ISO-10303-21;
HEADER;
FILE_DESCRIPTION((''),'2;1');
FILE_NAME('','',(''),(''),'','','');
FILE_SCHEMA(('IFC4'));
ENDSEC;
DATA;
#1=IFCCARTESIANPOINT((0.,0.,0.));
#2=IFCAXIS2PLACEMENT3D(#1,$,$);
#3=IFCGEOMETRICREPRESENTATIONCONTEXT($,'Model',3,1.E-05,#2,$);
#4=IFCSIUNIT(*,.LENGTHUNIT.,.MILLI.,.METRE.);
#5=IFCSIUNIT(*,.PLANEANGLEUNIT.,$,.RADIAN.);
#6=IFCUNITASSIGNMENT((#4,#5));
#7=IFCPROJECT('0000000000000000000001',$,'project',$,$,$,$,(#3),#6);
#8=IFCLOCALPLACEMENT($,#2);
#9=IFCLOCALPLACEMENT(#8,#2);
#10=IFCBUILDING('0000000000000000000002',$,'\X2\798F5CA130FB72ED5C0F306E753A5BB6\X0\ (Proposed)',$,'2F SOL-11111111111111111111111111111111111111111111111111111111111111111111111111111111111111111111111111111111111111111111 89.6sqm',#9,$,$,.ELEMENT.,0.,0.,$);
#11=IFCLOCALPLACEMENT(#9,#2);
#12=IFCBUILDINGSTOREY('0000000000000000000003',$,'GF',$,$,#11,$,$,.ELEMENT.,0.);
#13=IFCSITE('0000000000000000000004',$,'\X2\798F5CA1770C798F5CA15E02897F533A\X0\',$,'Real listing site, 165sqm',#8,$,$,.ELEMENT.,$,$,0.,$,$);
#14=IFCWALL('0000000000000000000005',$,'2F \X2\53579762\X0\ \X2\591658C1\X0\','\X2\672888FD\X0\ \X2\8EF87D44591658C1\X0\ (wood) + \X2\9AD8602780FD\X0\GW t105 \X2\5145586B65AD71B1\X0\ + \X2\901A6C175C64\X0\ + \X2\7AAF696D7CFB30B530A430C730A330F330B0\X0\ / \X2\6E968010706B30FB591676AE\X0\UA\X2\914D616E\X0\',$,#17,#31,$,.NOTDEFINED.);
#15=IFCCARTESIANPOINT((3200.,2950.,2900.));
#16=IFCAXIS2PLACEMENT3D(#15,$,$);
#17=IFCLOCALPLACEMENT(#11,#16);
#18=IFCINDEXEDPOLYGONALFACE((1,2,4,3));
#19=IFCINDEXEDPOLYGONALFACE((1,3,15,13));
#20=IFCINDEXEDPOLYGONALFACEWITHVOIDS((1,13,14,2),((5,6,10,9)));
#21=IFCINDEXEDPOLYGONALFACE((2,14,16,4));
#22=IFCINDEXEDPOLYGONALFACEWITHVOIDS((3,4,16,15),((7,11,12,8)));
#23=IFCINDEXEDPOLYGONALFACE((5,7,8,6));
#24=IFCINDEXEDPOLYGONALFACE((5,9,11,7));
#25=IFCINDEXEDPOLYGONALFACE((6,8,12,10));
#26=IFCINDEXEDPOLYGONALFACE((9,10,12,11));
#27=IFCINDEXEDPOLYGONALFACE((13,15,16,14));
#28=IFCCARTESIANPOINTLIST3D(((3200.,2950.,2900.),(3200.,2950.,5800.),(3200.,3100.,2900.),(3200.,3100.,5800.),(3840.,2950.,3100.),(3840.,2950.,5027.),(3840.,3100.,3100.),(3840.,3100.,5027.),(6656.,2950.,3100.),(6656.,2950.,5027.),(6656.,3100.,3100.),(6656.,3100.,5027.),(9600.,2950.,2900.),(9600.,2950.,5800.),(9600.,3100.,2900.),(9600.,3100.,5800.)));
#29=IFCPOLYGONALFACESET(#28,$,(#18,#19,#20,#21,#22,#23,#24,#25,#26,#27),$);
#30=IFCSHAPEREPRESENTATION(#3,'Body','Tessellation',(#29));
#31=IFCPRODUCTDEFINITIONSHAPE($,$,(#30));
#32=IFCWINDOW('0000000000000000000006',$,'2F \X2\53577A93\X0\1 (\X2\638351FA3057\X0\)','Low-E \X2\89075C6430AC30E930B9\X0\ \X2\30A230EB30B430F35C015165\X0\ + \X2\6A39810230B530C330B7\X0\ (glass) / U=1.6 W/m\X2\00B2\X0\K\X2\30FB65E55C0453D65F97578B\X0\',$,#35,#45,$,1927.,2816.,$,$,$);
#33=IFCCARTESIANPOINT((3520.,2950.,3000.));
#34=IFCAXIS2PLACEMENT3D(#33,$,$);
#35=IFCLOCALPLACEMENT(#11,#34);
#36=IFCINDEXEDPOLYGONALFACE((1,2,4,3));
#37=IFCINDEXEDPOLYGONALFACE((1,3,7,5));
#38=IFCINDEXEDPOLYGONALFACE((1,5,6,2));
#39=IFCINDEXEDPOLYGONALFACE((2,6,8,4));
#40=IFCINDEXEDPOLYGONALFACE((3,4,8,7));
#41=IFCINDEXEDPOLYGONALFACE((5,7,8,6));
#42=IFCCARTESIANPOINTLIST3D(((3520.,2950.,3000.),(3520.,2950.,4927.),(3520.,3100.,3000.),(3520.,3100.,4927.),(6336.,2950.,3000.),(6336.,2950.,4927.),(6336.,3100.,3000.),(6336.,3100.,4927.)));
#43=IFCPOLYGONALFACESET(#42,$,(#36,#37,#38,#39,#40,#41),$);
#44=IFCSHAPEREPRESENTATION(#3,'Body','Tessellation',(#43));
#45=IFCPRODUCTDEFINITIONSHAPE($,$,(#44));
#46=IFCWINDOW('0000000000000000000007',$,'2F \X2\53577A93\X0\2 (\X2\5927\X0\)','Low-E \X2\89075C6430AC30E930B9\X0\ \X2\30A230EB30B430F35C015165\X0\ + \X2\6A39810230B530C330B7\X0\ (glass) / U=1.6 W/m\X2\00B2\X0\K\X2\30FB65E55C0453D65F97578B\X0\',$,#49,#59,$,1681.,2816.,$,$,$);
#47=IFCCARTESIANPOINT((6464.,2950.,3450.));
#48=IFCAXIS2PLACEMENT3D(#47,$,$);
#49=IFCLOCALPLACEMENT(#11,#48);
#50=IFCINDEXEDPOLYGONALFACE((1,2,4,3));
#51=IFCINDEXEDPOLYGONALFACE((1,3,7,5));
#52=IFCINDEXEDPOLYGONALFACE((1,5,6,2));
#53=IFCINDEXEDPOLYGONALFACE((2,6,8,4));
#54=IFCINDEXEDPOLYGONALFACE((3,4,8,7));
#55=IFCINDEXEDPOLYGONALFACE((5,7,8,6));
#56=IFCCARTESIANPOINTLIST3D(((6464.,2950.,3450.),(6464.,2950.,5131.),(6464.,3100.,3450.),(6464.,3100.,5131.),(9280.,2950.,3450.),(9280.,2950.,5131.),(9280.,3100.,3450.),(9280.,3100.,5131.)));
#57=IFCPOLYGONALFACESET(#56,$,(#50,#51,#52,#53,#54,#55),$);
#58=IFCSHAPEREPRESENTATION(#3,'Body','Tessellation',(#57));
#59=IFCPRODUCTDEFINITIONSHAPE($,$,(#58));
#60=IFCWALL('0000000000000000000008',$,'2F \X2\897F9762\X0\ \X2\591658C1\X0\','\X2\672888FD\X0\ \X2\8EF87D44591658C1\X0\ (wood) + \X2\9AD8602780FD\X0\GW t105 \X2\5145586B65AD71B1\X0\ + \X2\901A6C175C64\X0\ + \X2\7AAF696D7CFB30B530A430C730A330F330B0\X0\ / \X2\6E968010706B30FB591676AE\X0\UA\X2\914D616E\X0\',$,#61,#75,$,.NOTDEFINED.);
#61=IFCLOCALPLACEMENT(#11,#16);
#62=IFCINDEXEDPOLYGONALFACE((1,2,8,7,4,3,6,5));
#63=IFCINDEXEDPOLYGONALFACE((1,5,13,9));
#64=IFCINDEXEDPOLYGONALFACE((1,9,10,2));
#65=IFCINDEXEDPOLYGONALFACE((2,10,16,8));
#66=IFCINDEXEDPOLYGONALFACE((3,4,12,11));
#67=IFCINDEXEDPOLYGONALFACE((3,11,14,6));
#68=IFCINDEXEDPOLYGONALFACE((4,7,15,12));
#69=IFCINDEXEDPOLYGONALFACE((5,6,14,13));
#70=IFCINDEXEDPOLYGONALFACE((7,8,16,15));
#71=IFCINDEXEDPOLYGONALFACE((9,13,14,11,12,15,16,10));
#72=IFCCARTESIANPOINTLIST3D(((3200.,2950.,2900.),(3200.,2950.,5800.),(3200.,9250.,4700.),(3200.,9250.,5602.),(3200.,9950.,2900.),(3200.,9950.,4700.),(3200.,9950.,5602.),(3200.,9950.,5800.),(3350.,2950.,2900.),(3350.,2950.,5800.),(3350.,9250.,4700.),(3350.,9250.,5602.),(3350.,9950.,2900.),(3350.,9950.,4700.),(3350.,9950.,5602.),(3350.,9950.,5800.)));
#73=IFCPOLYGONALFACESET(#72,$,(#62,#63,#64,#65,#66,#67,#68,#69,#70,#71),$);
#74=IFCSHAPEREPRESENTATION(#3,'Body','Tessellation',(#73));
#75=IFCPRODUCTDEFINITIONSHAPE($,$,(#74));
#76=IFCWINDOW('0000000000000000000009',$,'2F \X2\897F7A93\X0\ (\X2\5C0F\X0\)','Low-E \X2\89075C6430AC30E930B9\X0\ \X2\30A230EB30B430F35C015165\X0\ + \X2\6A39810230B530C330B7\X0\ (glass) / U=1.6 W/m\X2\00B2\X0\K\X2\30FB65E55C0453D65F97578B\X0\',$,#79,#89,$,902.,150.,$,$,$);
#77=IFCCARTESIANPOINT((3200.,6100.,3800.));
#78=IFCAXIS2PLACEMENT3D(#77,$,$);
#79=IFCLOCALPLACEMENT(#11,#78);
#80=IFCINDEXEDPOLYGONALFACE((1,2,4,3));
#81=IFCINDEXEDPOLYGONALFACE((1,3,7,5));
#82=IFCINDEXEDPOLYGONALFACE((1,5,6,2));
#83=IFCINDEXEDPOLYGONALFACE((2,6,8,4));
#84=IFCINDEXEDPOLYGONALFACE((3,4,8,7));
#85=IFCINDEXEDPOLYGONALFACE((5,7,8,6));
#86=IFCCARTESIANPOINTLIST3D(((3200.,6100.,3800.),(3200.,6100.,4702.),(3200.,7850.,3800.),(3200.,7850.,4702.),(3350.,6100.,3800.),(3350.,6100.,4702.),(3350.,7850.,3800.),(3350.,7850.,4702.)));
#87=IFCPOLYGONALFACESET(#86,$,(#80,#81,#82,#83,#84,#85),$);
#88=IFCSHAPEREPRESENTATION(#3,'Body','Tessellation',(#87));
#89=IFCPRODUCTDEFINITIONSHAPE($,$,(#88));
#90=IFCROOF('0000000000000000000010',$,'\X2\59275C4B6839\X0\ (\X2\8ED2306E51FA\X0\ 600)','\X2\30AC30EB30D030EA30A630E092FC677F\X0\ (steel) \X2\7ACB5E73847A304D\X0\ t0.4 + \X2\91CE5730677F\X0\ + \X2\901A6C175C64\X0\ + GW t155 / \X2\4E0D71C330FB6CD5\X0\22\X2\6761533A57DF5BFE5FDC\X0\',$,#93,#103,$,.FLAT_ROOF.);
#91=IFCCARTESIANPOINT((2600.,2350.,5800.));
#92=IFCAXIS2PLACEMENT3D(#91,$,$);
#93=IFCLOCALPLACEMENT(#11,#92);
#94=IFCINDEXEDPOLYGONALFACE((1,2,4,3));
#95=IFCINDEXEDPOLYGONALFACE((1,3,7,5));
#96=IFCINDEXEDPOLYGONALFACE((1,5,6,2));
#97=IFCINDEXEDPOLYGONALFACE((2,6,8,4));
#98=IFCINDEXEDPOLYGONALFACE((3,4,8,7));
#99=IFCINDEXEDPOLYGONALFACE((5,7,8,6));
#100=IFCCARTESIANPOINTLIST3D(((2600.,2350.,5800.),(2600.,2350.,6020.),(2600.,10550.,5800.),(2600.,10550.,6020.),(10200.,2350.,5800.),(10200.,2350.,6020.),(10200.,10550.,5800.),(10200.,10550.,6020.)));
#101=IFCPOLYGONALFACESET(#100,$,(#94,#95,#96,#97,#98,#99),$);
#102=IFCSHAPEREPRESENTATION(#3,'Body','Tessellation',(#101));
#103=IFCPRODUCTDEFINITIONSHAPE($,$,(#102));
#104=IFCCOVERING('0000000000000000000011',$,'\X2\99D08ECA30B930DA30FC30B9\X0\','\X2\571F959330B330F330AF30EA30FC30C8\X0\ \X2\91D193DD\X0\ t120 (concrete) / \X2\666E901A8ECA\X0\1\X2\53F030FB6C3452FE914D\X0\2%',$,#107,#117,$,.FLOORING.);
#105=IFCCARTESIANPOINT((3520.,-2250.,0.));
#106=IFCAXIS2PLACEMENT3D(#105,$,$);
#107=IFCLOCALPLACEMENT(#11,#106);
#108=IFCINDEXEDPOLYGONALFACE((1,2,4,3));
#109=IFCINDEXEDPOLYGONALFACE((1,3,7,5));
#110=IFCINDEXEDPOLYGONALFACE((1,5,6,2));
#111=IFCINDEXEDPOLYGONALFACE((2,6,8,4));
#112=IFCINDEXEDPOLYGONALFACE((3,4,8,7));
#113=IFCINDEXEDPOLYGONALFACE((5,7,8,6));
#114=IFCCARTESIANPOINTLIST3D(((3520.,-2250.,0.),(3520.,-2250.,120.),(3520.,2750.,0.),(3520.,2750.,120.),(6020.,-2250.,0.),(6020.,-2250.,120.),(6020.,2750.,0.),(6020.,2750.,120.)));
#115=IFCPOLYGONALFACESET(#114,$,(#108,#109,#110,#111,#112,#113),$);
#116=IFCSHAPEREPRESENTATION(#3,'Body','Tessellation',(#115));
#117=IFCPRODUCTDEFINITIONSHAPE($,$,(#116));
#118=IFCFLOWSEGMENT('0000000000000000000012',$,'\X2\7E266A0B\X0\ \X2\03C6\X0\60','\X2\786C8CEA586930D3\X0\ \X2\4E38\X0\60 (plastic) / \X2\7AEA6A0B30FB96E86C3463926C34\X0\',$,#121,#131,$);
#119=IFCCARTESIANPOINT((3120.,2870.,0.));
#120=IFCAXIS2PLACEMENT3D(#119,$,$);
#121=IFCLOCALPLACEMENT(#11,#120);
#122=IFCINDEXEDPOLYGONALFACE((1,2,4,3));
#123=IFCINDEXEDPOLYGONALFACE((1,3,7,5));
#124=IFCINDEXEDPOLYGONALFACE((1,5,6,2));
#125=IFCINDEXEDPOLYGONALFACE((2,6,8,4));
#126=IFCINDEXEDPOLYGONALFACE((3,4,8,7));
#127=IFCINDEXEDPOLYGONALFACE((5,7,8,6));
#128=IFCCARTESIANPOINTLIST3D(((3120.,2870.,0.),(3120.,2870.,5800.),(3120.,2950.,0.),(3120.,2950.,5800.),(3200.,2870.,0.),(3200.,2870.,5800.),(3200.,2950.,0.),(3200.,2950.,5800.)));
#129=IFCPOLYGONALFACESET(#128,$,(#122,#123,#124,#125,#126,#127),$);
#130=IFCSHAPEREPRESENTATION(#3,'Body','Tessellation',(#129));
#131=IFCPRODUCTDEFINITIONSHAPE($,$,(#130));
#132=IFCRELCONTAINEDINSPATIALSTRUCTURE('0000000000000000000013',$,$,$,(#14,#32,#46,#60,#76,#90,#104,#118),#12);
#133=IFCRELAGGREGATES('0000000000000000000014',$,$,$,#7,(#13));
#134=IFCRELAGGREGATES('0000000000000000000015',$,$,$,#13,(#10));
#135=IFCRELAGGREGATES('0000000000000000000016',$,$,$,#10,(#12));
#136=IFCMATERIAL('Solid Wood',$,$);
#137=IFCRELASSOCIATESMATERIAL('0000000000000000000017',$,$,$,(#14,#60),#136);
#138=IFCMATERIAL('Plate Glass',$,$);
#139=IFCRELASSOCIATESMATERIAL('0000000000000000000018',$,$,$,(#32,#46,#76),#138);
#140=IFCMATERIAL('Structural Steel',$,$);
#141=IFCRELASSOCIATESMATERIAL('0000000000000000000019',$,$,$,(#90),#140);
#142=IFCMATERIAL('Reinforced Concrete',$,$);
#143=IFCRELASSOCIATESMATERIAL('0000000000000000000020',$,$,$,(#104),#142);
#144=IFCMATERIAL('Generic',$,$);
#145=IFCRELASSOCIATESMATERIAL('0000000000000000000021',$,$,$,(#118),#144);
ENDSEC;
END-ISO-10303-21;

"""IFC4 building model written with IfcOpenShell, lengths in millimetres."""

from ifc_helpers import new_model, si_unit, frame, frame_2d, origin, place, context, project, spatial, rectangle, extrude, material, element, fill, save


model = new_model("IFC4")

# Units and contexts
model_context = context("Model", 3, precision=1e-05, world=origin())
ifc_project = project(units=[si_unit("LENGTHUNIT", "METRE", prefix="MILLI"), si_unit("PLANEANGLEUNIT", "RADIAN")], contexts=[model_context])

# Site, building, storey
site_placement = place(None, origin())
site = spatial("IfcSite", under=ifc_project, at=site_placement, Name="福岡県福岡市西区", ObjectType="Real listing site, 165sqm", CompositionType="ELEMENT", RefElevation=0.0)
building_placement = place(site_placement, origin())
building = spatial("IfcBuilding", under=site, at=building_placement, Name="福岡・狭小の町家 (Proposed)", ObjectType="2F SOL-11111111111111111111111111111111111111111111111111111111111111111111111111111111111111111111111111111111111111111111 89.6sqm", CompositionType="ELEMENT", ElevationOfRefHeight=0.0, ElevationOfTerrain=0.0)
storey_placement = place(building_placement, origin())
storey = spatial("IfcBuildingStorey", under=building, at=storey_placement, Name="GF", CompositionType="ELEMENT", Elevation=0.0)

# Shared definitions
ifc_material_1 = material(Name="Solid Wood")

# Shared definitions
ifc_material_2 = material(Name="Reinforced Concrete")

# Shared definitions
ifc_material_3 = material(Name="Plate Glass")

# Wall, openings, windows
wall_1_placement = place(storey_placement, frame((3200.0, 2950.0, 2900.0)))
wall_1 = element("IfcWall", 1, at=wall_1_placement, inside=storey, material=ifc_material_1, Name="2F 南面 外壁", Description="木製 軸組外壁 (wood) + 高性能GW t105 充填断熱 + 通気層 + 窯業系サイディング / 準耐火・外皮UA配慮", PredefinedType="NOTDEFINED", context=model_context, shape_type="SweptSolid", body=[
    extrude(rectangle(XDim=6400.0, YDim=150.0, at=frame_2d((3200.0, 75.0))), frame((3200.0, 2950.0, 2900.0)), (0.0, 0.0, 1.0), 2900.0),
])
opening_1_placement = place(storey_placement, frame((3520.0, 2950.0, 3000.0)))
opening_1 = element("IfcOpeningElement", 2, at=opening_1_placement, cuts=wall_1, PredefinedType="NOTDEFINED", context=model_context, shape_type="SweptSolid", body=[
    extrude(rectangle(XDim=2816.0, YDim=150.0, at=frame_2d((1408.0, 75.0))), frame((3520.0, 2950.0, 3000.0)), (0.0, 0.0, 1.0), 1927.0),
])
opening_2_placement = place(storey_placement, frame((6464.0, 2950.0, 3450.0)))
opening_2 = element("IfcOpeningElement", 3, at=opening_2_placement, cuts=wall_1, PredefinedType="NOTDEFINED", context=model_context, shape_type="SweptSolid", body=[
    extrude(rectangle(XDim=2816.0, YDim=150.0, at=frame_2d((1408.0, 75.0))), frame((6464.0, 2950.0, 3450.0)), (0.0, 0.0, 1.0), 1681.0),
])
window_1_placement = place(storey_placement, frame((3520.0, 2950.0, 3000.0)))
window_1 = element("IfcWindow", 4, at=window_1_placement, inside=storey, material=ifc_material_3, Name="2F 南窓1 (掃出し)", Description="Low-E 複層ガラス アルゴン封入 + 樹脂サッシ (glass) / U=1.6 W/m²K・日射取得型", OverallHeight=1927.0, OverallWidth=2816.0, context=model_context, shape_type="SweptSolid", body=[
    extrude(rectangle(XDim=2816.0, YDim=150.0, at=frame_2d((1408.0, 75.0))), frame((3520.0, 2950.0, 3000.0)), (0.0, 0.0, 1.0), 1927.0),
])
fill(opening_1, window_1)
window_2_placement = place(storey_placement, frame((6464.0, 2950.0, 3450.0)))
window_2 = element("IfcWindow", 5, at=window_2_placement, inside=storey, material=ifc_material_3, Name="2F 南窓2 (大)", Description="Low-E 複層ガラス アルゴン封入 + 樹脂サッシ (glass) / U=1.6 W/m²K・日射取得型", OverallHeight=1681.0, OverallWidth=2816.0, context=model_context, shape_type="SweptSolid", body=[
    extrude(rectangle(XDim=2816.0, YDim=150.0, at=frame_2d((1408.0, 75.0))), frame((6464.0, 2950.0, 3450.0)), (0.0, 0.0, 1.0), 1681.0),
])
fill(opening_2, window_2)

# Wall, opening, window
wall_2_placement = place(storey_placement, frame((3200.0, 2950.0, 2900.0)))
wall_2 = element("IfcWall", 6, at=wall_2_placement, inside=storey, material=ifc_material_1, Name="2F 西面 外壁", Description="木製 軸組外壁 (wood) + 高性能GW t105 充填断熱 + 通気層 + 窯業系サイディング / 準耐火・外皮UA配慮", PredefinedType="NOTDEFINED", context=model_context, shape_type="SweptSolid", body=[
    extrude(rectangle(XDim=150.0, YDim=7000.0, at=frame_2d((75.0, 3500.0))), frame((3200.0, 2950.0, 2900.0)), (0.0, 0.0, 1.0), 2900.0),
])
opening_3_placement = place(storey_placement, frame((3200.0, 6100.0, 3800.0)))
opening_3 = element("IfcOpeningElement", 7, at=opening_3_placement, cuts=wall_2, PredefinedType="NOTDEFINED", context=model_context, shape_type="SweptSolid", body=[
    extrude(rectangle(XDim=150.0, YDim=1750.0, at=frame_2d((75.0, 875.0))), frame((3200.0, 6100.0, 3800.0)), (0.0, 0.0, 1.0), 902.0),
])
window_3_placement = place(storey_placement, frame((3200.0, 6100.0, 3800.0)))
window_3 = element("IfcWindow", 8, at=window_3_placement, inside=storey, material=ifc_material_3, Name="2F 西窓 (小)", Description="Low-E 複層ガラス アルゴン封入 + 樹脂サッシ (glass) / U=1.6 W/m²K・日射取得型", OverallHeight=902.0, OverallWidth=150.0, context=model_context, shape_type="SweptSolid", body=[
    extrude(rectangle(XDim=150.0, YDim=1750.0, at=frame_2d((75.0, 875.0))), frame((3200.0, 6100.0, 3800.0)), (0.0, 0.0, 1.0), 902.0),
])
fill(opening_3, window_3)

# Roof
ifc_material_4 = material(Name="Structural Steel")
roof_placement = place(storey_placement, frame((2600.0, 2350.0, 5800.0)))
element("IfcRoof", 9, at=roof_placement, inside=storey, material=ifc_material_4, Name="大屋根 (軒の出 600)", Description="ガルバリウム鋼板 (steel) 立平葺き t0.4 + 野地板 + 通気層 + GW t155 / 不燃・法22条区域対応", PredefinedType="FLAT_ROOF", context=model_context, shape_type="SweptSolid", body=[
    extrude(rectangle(XDim=7600.0, YDim=8200.0, at=frame_2d((3800.0, 4100.0))), frame((2600.0, 2350.0, 5800.0)), (0.0, 0.0, 1.0), 220.0),
])

# Covering
covering_placement = place(storey_placement, frame((3520.0, -2250.0, 0.0)))
element("IfcCovering", 10, at=covering_placement, inside=storey, material=ifc_material_2, Name="駐車スペース", Description="土間コンクリート 金鏝 t120 (concrete) / 普通車1台・水勾配2%", PredefinedType="FLOORING", context=model_context, shape_type="SweptSolid", body=[
    extrude(rectangle(XDim=2500.0, YDim=5000.0, at=frame_2d((1250.0, 2500.0))), frame((3520.0, -2250.0, 0.0)), (0.0, 0.0, 1.0), 120.0),
])

# Flow segment
ifc_material_5 = material(Name="Generic")
flow_segment_1_placement = place(storey_placement, frame((3120.0, 2870.0, 0.0)))
element("IfcFlowSegment", 11, at=flow_segment_1_placement, inside=storey, material=ifc_material_5, Name="縦樋 φ60", Description="硬質塩ビ 丸60 (plastic) / 竪樋・雨水排水", context=model_context, shape_type="SweptSolid", body=[
    extrude(rectangle(XDim=80.0, YDim=80.0, at=frame_2d((40.0, 40.0))), frame((3120.0, 2870.0, 0.0)), (0.0, 0.0, 1.0), 5800.0),
])

save(model, "model.ifc")
